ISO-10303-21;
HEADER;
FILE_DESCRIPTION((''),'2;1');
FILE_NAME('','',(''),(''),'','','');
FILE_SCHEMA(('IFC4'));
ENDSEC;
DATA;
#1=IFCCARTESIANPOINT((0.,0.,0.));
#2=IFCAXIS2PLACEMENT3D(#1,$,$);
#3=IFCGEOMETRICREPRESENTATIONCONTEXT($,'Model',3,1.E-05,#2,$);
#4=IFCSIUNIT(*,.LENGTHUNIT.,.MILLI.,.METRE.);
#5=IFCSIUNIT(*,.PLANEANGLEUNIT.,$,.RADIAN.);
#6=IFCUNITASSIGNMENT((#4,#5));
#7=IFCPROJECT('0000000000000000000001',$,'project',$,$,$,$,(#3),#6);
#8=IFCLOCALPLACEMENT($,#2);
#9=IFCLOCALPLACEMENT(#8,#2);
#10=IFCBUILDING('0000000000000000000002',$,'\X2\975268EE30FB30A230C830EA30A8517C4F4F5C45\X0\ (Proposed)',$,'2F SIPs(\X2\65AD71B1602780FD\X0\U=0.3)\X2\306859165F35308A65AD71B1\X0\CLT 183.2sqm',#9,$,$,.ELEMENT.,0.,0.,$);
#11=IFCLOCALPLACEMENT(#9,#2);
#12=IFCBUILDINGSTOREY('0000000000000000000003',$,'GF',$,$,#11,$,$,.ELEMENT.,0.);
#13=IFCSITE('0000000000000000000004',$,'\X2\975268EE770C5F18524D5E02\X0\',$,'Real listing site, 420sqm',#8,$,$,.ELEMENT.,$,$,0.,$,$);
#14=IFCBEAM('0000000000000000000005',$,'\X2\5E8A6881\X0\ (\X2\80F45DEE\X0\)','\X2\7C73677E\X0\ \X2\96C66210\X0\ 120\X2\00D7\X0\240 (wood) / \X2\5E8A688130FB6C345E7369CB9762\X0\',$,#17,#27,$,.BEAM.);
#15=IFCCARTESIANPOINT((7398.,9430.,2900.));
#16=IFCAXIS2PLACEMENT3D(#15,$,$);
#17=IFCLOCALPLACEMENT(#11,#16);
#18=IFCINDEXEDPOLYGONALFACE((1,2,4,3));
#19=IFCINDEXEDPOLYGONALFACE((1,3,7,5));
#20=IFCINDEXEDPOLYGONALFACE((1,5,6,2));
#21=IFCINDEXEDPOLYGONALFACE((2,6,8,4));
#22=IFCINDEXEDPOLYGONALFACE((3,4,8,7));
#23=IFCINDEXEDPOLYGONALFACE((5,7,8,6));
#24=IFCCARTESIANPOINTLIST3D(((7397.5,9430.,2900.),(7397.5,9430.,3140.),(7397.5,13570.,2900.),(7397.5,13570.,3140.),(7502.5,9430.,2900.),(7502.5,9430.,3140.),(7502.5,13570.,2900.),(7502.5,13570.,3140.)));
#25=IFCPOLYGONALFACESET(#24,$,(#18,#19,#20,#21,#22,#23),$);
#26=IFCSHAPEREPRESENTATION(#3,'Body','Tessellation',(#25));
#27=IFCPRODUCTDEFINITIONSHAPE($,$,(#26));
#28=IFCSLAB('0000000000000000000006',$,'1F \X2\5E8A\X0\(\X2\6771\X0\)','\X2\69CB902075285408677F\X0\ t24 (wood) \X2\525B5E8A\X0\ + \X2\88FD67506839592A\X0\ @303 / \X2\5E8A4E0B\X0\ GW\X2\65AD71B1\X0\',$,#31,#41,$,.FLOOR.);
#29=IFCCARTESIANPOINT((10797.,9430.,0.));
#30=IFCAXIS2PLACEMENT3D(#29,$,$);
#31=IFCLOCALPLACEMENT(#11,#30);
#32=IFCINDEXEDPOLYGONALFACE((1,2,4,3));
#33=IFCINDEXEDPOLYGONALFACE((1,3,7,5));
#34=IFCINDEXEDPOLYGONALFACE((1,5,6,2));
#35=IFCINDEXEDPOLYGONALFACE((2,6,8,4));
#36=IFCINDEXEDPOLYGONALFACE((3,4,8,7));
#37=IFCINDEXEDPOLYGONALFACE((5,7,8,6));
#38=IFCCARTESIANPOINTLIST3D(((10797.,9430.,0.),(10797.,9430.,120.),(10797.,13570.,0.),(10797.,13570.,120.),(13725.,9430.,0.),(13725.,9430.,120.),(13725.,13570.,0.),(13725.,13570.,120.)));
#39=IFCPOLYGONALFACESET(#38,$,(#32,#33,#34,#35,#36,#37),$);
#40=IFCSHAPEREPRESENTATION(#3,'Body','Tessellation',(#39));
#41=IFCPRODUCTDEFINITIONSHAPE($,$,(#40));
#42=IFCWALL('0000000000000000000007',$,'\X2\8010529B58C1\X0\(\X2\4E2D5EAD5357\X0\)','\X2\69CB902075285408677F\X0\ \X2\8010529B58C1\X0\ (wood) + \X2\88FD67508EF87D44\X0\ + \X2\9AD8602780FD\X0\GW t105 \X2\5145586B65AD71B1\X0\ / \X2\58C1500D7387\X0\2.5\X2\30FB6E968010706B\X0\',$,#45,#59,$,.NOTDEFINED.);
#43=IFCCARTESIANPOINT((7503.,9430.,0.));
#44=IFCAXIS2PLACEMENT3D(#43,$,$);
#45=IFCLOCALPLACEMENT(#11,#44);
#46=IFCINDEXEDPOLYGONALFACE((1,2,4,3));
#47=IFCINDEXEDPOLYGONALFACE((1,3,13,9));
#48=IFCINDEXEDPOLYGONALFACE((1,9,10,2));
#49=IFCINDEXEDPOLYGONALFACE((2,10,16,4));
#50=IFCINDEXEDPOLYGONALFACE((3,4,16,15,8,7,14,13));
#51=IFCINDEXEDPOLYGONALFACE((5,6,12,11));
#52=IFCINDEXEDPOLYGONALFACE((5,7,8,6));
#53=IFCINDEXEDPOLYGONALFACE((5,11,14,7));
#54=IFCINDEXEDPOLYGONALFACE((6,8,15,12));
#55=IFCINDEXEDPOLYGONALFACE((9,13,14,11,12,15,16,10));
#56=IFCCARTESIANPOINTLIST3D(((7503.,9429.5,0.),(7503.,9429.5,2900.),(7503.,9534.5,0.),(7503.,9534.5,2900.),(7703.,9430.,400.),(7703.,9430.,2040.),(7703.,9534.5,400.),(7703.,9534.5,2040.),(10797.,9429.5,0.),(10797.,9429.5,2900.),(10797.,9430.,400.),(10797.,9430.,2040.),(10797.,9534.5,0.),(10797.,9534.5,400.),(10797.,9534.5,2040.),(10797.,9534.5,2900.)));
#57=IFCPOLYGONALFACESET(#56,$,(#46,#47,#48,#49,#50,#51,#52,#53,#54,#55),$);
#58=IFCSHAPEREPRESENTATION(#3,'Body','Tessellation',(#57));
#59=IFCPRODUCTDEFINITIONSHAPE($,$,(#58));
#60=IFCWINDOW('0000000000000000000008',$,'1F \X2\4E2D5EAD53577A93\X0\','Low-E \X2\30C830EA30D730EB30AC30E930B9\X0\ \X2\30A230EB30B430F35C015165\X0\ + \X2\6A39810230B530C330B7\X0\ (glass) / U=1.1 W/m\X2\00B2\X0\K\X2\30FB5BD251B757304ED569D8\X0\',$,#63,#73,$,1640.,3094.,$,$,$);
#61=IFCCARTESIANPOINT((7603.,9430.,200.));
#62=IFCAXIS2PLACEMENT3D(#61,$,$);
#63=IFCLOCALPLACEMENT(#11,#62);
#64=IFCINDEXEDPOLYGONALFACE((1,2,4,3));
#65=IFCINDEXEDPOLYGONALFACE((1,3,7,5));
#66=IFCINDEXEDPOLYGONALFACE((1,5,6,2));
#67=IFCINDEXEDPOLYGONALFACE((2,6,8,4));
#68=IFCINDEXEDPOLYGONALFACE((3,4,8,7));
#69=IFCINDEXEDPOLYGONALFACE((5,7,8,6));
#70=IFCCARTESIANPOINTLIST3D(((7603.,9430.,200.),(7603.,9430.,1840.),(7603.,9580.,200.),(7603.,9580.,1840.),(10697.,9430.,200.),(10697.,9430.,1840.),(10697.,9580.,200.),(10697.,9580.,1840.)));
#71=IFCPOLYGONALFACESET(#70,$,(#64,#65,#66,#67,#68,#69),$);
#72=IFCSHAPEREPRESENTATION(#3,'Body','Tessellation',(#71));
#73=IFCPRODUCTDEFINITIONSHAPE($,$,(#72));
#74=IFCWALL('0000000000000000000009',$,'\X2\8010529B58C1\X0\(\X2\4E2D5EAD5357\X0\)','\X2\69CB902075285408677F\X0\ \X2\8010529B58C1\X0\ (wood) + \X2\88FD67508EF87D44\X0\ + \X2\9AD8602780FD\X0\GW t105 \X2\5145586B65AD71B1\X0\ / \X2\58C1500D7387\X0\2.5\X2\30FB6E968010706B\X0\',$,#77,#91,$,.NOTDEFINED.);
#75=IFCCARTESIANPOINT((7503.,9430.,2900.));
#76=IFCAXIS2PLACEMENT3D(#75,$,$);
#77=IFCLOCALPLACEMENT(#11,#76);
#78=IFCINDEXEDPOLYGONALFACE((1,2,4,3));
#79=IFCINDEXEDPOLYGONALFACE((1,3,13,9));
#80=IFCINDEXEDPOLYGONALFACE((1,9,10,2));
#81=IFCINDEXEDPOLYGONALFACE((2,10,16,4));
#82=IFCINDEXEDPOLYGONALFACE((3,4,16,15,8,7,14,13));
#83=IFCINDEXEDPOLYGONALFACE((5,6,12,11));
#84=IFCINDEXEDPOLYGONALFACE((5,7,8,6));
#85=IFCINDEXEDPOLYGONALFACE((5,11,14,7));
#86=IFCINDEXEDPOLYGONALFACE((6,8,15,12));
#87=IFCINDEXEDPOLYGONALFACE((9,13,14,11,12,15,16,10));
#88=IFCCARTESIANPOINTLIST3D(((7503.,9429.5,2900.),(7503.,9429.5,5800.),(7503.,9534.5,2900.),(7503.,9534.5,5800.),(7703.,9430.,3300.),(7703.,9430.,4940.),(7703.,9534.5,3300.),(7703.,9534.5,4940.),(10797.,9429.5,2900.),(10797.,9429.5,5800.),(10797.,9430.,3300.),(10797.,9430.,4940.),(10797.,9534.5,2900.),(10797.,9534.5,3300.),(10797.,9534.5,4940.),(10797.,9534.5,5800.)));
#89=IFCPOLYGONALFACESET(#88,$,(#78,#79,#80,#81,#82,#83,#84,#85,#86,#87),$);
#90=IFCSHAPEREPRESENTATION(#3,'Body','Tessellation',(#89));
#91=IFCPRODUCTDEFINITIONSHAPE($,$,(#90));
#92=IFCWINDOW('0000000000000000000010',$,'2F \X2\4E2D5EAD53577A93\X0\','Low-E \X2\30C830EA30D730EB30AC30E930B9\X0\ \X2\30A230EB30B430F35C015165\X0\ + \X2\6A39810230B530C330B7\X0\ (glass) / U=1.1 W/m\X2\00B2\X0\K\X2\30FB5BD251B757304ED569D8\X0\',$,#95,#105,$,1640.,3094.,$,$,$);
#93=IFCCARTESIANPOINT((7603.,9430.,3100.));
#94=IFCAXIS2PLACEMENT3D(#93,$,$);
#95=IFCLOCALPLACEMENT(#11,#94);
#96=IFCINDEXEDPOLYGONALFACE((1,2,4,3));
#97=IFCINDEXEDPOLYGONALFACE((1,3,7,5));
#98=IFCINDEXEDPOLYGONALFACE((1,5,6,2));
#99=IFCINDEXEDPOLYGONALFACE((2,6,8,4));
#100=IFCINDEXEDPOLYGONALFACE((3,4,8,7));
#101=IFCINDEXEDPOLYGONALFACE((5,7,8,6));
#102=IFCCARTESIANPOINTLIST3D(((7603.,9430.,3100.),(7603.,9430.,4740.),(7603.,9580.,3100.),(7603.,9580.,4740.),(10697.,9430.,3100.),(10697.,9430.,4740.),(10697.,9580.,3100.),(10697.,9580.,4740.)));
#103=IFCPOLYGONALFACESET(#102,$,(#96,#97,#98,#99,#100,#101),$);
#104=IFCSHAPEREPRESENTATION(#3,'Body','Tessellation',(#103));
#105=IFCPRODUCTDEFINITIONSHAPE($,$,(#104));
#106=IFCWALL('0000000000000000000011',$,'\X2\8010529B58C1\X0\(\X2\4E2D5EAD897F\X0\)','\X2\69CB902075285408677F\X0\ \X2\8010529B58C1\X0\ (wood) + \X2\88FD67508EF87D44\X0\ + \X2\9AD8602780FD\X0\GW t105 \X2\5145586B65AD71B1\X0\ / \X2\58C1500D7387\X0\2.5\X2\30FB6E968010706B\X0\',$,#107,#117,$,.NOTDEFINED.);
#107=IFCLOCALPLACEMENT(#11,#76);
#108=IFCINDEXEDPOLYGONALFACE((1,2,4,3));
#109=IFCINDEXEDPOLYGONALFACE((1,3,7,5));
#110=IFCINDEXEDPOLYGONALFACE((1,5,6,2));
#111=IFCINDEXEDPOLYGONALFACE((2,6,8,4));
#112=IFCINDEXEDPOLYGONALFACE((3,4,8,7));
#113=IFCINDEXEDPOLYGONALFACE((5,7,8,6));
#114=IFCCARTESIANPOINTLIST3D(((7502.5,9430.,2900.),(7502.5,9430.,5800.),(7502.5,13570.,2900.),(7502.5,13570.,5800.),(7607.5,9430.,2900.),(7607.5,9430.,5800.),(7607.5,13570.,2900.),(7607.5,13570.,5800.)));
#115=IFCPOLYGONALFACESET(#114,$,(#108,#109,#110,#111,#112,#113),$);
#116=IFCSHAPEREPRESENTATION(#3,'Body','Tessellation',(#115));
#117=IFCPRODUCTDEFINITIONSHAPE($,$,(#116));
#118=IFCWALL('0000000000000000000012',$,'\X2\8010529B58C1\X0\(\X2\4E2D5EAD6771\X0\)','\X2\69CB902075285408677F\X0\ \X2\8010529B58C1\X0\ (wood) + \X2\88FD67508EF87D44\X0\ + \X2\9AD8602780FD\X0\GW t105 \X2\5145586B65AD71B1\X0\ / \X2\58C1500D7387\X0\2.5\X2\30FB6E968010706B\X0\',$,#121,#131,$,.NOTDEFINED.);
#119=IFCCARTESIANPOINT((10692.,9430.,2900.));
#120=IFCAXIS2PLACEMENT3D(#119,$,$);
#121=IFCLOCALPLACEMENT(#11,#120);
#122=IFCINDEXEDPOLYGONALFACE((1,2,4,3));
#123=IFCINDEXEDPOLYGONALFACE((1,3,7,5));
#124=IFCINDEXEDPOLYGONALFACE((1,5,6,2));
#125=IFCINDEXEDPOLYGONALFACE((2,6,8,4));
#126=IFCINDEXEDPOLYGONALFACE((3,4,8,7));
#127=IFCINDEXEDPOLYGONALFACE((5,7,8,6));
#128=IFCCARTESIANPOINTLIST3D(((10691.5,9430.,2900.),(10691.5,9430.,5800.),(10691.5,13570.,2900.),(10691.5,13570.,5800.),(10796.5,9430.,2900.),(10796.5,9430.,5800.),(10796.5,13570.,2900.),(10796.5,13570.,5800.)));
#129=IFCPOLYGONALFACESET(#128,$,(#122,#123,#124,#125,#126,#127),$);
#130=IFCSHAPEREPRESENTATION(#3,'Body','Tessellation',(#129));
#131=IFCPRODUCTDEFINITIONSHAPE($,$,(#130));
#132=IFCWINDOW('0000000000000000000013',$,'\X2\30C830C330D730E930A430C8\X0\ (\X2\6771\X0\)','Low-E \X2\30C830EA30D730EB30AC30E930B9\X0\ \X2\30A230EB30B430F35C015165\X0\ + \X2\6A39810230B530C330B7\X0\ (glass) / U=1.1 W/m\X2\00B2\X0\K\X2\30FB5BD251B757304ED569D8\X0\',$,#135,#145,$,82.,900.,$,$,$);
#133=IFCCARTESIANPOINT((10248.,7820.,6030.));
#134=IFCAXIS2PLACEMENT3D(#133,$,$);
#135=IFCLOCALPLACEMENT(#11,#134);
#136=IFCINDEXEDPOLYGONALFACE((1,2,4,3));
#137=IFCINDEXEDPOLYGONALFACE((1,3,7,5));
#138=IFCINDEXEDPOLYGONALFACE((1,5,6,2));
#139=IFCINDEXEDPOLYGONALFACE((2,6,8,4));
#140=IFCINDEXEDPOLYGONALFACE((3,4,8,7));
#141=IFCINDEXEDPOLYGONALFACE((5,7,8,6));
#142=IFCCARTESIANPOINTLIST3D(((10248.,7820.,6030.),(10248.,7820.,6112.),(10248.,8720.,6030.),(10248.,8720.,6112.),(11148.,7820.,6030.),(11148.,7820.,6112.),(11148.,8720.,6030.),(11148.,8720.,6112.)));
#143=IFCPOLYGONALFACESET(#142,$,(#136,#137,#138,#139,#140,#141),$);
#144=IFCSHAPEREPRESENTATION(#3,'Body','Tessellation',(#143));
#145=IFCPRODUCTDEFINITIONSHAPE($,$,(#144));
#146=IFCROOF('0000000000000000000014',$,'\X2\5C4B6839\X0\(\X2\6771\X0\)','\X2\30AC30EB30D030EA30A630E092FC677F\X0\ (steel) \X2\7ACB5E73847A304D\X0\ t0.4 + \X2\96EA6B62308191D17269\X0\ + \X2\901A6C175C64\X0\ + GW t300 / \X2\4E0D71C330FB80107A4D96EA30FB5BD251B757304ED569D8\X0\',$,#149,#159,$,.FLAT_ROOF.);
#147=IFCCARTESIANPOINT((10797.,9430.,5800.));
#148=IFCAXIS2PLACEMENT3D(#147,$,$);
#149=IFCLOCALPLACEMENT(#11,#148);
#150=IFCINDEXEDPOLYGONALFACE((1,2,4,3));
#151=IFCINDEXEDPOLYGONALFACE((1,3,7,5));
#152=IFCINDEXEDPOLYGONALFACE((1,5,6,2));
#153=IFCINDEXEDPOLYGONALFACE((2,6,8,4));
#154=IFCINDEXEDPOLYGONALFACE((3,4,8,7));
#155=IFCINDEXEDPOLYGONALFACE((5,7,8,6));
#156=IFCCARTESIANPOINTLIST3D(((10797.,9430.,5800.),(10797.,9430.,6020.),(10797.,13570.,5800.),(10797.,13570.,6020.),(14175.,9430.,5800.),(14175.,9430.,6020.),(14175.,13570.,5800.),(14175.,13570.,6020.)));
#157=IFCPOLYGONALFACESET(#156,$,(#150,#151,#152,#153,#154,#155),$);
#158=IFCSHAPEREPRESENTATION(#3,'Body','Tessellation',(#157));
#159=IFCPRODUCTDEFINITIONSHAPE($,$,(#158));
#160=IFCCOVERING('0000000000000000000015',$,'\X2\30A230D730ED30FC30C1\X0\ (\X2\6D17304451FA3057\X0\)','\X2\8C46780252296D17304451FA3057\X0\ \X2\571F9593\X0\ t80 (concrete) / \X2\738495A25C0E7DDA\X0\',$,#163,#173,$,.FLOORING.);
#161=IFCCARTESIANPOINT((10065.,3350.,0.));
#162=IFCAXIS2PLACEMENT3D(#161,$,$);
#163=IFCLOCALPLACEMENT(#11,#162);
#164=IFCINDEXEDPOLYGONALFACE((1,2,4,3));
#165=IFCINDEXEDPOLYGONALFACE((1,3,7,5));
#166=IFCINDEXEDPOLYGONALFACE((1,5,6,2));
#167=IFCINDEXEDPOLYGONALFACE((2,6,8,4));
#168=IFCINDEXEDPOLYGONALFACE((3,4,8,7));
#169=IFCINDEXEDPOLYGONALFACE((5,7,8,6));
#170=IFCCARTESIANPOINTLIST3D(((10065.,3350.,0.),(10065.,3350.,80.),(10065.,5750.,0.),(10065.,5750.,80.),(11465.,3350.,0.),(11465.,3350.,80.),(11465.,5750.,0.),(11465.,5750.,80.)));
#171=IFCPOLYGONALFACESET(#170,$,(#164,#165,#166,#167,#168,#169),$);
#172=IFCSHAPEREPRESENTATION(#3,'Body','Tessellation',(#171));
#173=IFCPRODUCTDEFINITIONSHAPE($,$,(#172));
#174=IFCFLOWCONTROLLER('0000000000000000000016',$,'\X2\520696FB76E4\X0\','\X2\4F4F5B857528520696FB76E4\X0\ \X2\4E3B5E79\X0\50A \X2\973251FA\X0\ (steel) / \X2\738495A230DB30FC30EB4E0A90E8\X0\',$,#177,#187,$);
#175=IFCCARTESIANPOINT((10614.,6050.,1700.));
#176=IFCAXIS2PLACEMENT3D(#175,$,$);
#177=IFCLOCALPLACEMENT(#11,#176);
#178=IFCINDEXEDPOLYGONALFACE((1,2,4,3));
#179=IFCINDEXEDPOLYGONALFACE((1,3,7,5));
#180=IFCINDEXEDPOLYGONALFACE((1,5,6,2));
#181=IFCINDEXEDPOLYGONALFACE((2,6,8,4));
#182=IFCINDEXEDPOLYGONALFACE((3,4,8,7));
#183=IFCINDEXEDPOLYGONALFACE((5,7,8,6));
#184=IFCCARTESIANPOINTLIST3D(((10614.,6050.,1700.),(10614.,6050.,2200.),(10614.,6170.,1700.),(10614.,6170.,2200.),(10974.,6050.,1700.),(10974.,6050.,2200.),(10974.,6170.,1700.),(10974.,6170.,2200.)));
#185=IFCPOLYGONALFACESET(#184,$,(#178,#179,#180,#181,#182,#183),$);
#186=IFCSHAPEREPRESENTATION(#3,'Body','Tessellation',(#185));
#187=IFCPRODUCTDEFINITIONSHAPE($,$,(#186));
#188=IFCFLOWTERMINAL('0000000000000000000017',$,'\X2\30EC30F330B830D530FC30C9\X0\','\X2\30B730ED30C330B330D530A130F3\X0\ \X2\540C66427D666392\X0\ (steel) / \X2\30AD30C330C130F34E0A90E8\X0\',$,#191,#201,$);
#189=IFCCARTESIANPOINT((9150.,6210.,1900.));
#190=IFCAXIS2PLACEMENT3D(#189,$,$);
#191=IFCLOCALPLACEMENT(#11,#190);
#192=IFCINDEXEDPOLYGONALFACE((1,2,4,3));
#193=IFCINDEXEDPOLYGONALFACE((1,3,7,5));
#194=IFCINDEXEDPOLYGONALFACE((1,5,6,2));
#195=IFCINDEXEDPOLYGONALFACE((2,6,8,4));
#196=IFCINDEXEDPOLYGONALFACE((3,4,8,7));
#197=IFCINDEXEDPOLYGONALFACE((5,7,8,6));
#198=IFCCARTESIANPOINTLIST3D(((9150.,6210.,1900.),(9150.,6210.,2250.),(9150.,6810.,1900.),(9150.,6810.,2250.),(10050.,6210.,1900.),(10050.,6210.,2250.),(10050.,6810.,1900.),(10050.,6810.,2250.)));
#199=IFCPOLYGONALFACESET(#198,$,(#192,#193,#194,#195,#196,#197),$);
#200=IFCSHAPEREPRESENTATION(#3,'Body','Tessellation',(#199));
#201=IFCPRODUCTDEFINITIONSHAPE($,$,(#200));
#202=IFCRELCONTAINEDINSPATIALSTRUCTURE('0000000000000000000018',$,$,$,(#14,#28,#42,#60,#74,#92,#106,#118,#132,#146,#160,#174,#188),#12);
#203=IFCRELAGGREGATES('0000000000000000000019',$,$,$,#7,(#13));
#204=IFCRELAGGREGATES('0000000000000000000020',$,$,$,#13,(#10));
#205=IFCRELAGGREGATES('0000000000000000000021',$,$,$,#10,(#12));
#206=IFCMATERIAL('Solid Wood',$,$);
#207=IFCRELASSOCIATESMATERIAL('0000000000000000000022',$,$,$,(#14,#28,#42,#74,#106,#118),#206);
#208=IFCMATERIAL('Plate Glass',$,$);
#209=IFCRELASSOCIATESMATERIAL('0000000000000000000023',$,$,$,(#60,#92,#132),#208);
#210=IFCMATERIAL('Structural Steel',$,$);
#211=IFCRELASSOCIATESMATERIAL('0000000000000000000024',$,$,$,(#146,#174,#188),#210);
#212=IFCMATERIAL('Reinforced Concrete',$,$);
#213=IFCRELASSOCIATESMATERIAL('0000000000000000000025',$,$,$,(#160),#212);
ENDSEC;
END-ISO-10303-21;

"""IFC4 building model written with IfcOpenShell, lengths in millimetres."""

from ifc_helpers import new_model, si_unit, frame, frame_2d, origin, place, context, project, spatial, rectangle, extrude, material, element, fill, save


model = new_model("IFC4")

# Units and contexts
model_context = context("Model", 3, precision=1e-05, world=origin())
ifc_project = project(units=[si_unit("LENGTHUNIT", "METRE", prefix="MILLI"), si_unit("PLANEANGLEUNIT", "RADIAN")], contexts=[model_context])

# Site, building, storey
site_placement = place(None, origin())
site = spatial("IfcSite", under=ifc_project, at=site_placement, Name="青森県弘前市", ObjectType="Real listing site, 420sqm", CompositionType="ELEMENT", RefElevation=0.0)
building_placement = place(site_placement, origin())
building = spatial("IfcBuilding", under=site, at=building_placement, Name="青森・アトリエ兼住居 (Proposed)", ObjectType="2F SIPs(断熱性能U=0.3)と外張り断熱CLT 183.2sqm", CompositionType="ELEMENT", ElevationOfRefHeight=0.0, ElevationOfTerrain=0.0)
storey_placement = place(building_placement, origin())
storey = spatial("IfcBuildingStorey", under=building, at=storey_placement, Name="GF", CompositionType="ELEMENT", Elevation=0.0)

# Shared definitions
ifc_material_1 = material(Name="Solid Wood")

# Beam
beam_placement = place(storey_placement, frame((7398.0, 9430.0, 2900.0)))
element("IfcBeam", 1, at=beam_placement, inside=storey, material=ifc_material_1, Name="床梁 (胴差)", Description="米松 集成 120×240 (wood) / 床梁・水平構面", PredefinedType="BEAM", context=model_context, shape_type="SweptSolid", body=[
    extrude(rectangle(XDim=105.0, YDim=4140.0, at=frame_2d((52.0, 2070.0))), frame((7398.0, 9430.0, 2900.0)), (0.0, 0.0, 1.0), 240.0),
])

# Slab
slab_placement = place(storey_placement, frame((10797.0, 9430.0, 0.0)))
element("IfcSlab", 2, at=slab_placement, inside=storey, material=ifc_material_1, Name="1F 床(東)", Description="構造用合板 t24 (wood) 剛床 + 製材根太 @303 / 床下 GW断熱", PredefinedType="FLOOR", context=model_context, shape_type="SweptSolid", body=[
    extrude(rectangle(XDim=2928.0, YDim=4140.0, at=frame_2d((1464.0, 2070.0))), frame((10797.0, 9430.0, 0.0)), (0.0, 0.0, 1.0), 120.0),
])

# Wall, opening, window
wall_1_placement = place(storey_placement, frame((7503.0, 9430.0, 0.0)))
wall_1 = element("IfcWall", 3, at=wall_1_placement, inside=storey, material=ifc_material_1, Name="耐力壁(中庭南)", Description="構造用合板 耐力壁 (wood) + 製材軸組 + 高性能GW t105 充填断熱 / 壁倍率2.5・準耐火", PredefinedType="NOTDEFINED", context=model_context, shape_type="SweptSolid", body=[
    extrude(rectangle(XDim=3294.0, YDim=105.0, at=frame_2d((1647.0, 52.0))), frame((7503.0, 9430.0, 0.0)), (0.0, 0.0, 1.0), 2900.0),
])
opening_1_placement = place(storey_placement, frame((7603.0, 9430.0, 200.0)))
opening_1 = element("IfcOpeningElement", 4, at=opening_1_placement, cuts=wall_1, PredefinedType="NOTDEFINED", context=model_context, shape_type="SweptSolid", body=[
    extrude(rectangle(XDim=3094.0, YDim=150.0, at=frame_2d((1547.0, 75.0))), frame((7603.0, 9430.0, 200.0)), (0.0, 0.0, 1.0), 1640.0),
])
ifc_material_2 = material(Name="Plate Glass")
window_1_placement = place(storey_placement, frame((7603.0, 9430.0, 200.0)))
window_1 = element("IfcWindow", 5, at=window_1_placement, inside=storey, material=ifc_material_2, Name="1F 中庭南窓", Description="Low-E トリプルガラス アルゴン封入 + 樹脂サッシ (glass) / U=1.1 W/m²K・寒冷地仕様", OverallHeight=1640.0, OverallWidth=3094.0, context=model_context, shape_type="SweptSolid", body=[
    extrude(rectangle(XDim=3094.0, YDim=150.0, at=frame_2d((1547.0, 75.0))), frame((7603.0, 9430.0, 200.0)), (0.0, 0.0, 1.0), 1640.0),
])
fill(opening_1, window_1)

# Wall, opening, window
wall_2_placement = place(storey_placement, frame((7503.0, 9430.0, 2900.0)))
wall_2 = element("IfcWall", 6, at=wall_2_placement, inside=storey, material=ifc_material_1, Name="耐力壁(中庭南)", Description="構造用合板 耐力壁 (wood) + 製材軸組 + 高性能GW t105 充填断熱 / 壁倍率2.5・準耐火", PredefinedType="NOTDEFINED", context=model_context, shape_type="SweptSolid", body=[
    extrude(rectangle(XDim=3294.0, YDim=105.0, at=frame_2d((1647.0, 52.0))), frame((7503.0, 9430.0, 2900.0)), (0.0, 0.0, 1.0), 2900.0),
])
opening_2_placement = place(storey_placement, frame((7603.0, 9430.0, 3100.0)))
opening_2 = element("IfcOpeningElement", 7, at=opening_2_placement, cuts=wall_2, PredefinedType="NOTDEFINED", context=model_context, shape_type="SweptSolid", body=[
    extrude(rectangle(XDim=3094.0, YDim=150.0, at=frame_2d((1547.0, 75.0))), frame((7603.0, 9430.0, 3100.0)), (0.0, 0.0, 1.0), 1640.0),
])
window_2_placement = place(storey_placement, frame((7603.0, 9430.0, 3100.0)))
window_2 = element("IfcWindow", 8, at=window_2_placement, inside=storey, material=ifc_material_2, Name="2F 中庭南窓", Description="Low-E トリプルガラス アルゴン封入 + 樹脂サッシ (glass) / U=1.1 W/m²K・寒冷地仕様", OverallHeight=1640.0, OverallWidth=3094.0, context=model_context, shape_type="SweptSolid", body=[
    extrude(rectangle(XDim=3094.0, YDim=150.0, at=frame_2d((1547.0, 75.0))), frame((7603.0, 9430.0, 3100.0)), (0.0, 0.0, 1.0), 1640.0),
])
fill(opening_2, window_2)

# Walls
wall_3_placement = place(storey_placement, frame((7503.0, 9430.0, 2900.0)))
element("IfcWall", 9, at=wall_3_placement, inside=storey, material=ifc_material_1, Name="耐力壁(中庭西)", Description="構造用合板 耐力壁 (wood) + 製材軸組 + 高性能GW t105 充填断熱 / 壁倍率2.5・準耐火", PredefinedType="NOTDEFINED", context=model_context, shape_type="SweptSolid", body=[
    extrude(rectangle(XDim=105.0, YDim=4140.0, at=frame_2d((52.0, 2070.0))), frame((7503.0, 9430.0, 2900.0)), (0.0, 0.0, 1.0), 2900.0),
])
wall_4_placement = place(storey_placement, frame((10692.0, 9430.0, 2900.0)))
element("IfcWall", 10, at=wall_4_placement, inside=storey, material=ifc_material_1, Name="耐力壁(中庭東)", Description="構造用合板 耐力壁 (wood) + 製材軸組 + 高性能GW t105 充填断熱 / 壁倍率2.5・準耐火", PredefinedType="NOTDEFINED", context=model_context, shape_type="SweptSolid", body=[
    extrude(rectangle(XDim=105.0, YDim=4140.0, at=frame_2d((52.0, 2070.0))), frame((10692.0, 9430.0, 2900.0)), (0.0, 0.0, 1.0), 2900.0),
])

# Window
window_3_placement = place(storey_placement, frame((10248.0, 7820.0, 6030.0)))
element("IfcWindow", 11, at=window_3_placement, inside=storey, material=ifc_material_2, Name="トップライト (東)", Description="Low-E トリプルガラス アルゴン封入 + 樹脂サッシ (glass) / U=1.1 W/m²K・寒冷地仕様", OverallHeight=82.0, OverallWidth=900.0, context=model_context, shape_type="SweptSolid", body=[
    extrude(rectangle(XDim=900.0, YDim=900.0, at=frame_2d((450.0, 450.0))), frame((10248.0, 7820.0, 6030.0)), (0.0, 0.0, 1.0), 82.0),
])

# Roof
ifc_material_3 = material(Name="Structural Steel")
roof_placement = place(storey_placement, frame((10797.0, 9430.0, 5800.0)))
element("IfcRoof", 12, at=roof_placement, inside=storey, material=ifc_material_3, Name="屋根(東)", Description="ガルバリウム鋼板 (steel) 立平葺き t0.4 + 雪止め金物 + 通気層 + GW t300 / 不燃・耐積雪・寒冷地仕様", PredefinedType="FLAT_ROOF", context=model_context, shape_type="SweptSolid", body=[
    extrude(rectangle(XDim=3378.0, YDim=4140.0, at=frame_2d((1689.0, 2070.0))), frame((10797.0, 9430.0, 5800.0)), (0.0, 0.0, 1.0), 220.0),
])

# Covering
ifc_material_4 = material(Name="Reinforced Concrete")
covering_placement = place(storey_placement, frame((10065.0, 3350.0, 0.0)))
element("IfcCovering", 13, at=covering_placement, inside=storey, material=ifc_material_4, Name="アプローチ (洗い出し)", Description="豆砂利洗い出し 土間 t80 (concrete) / 玄関導線", PredefinedType="FLOORING", context=model_context, shape_type="SweptSolid", body=[
    extrude(rectangle(XDim=1400.0, YDim=2400.0, at=frame_2d((700.0, 1200.0))), frame((10065.0, 3350.0, 0.0)), (0.0, 0.0, 1.0), 80.0),
])

# Flow controller
flow_controller_placement = place(storey_placement, frame((10614.0, 6050.0, 1700.0)))
element("IfcFlowController", 14, at=flow_controller_placement, inside=storey, material=ifc_material_3, Name="分電盤", Description="住宅用分電盤 主幹50A 露出 (steel) / 玄関ホール上部", context=model_context, shape_type="SweptSolid", body=[
    extrude(rectangle(XDim=360.0, YDim=120.0, at=frame_2d((180.0, 60.0))), frame((10614.0, 6050.0, 1700.0)), (0.0, 0.0, 1.0), 500.0),
])

# Flow terminal
flow_terminal_1_placement = place(storey_placement, frame((9150.0, 6210.0, 1900.0)))
element("IfcFlowTerminal", 15, at=flow_terminal_1_placement, inside=storey, material=ifc_material_3, Name="レンジフード", Description="シロッコファン 同時給排 (steel) / キッチン上部", context=model_context, shape_type="SweptSolid", body=[
    extrude(rectangle(XDim=900.0, YDim=600.0, at=frame_2d((450.0, 300.0))), frame((9150.0, 6210.0, 1900.0)), (0.0, 0.0, 1.0), 350.0),
])

save(model, "model.ifc")
